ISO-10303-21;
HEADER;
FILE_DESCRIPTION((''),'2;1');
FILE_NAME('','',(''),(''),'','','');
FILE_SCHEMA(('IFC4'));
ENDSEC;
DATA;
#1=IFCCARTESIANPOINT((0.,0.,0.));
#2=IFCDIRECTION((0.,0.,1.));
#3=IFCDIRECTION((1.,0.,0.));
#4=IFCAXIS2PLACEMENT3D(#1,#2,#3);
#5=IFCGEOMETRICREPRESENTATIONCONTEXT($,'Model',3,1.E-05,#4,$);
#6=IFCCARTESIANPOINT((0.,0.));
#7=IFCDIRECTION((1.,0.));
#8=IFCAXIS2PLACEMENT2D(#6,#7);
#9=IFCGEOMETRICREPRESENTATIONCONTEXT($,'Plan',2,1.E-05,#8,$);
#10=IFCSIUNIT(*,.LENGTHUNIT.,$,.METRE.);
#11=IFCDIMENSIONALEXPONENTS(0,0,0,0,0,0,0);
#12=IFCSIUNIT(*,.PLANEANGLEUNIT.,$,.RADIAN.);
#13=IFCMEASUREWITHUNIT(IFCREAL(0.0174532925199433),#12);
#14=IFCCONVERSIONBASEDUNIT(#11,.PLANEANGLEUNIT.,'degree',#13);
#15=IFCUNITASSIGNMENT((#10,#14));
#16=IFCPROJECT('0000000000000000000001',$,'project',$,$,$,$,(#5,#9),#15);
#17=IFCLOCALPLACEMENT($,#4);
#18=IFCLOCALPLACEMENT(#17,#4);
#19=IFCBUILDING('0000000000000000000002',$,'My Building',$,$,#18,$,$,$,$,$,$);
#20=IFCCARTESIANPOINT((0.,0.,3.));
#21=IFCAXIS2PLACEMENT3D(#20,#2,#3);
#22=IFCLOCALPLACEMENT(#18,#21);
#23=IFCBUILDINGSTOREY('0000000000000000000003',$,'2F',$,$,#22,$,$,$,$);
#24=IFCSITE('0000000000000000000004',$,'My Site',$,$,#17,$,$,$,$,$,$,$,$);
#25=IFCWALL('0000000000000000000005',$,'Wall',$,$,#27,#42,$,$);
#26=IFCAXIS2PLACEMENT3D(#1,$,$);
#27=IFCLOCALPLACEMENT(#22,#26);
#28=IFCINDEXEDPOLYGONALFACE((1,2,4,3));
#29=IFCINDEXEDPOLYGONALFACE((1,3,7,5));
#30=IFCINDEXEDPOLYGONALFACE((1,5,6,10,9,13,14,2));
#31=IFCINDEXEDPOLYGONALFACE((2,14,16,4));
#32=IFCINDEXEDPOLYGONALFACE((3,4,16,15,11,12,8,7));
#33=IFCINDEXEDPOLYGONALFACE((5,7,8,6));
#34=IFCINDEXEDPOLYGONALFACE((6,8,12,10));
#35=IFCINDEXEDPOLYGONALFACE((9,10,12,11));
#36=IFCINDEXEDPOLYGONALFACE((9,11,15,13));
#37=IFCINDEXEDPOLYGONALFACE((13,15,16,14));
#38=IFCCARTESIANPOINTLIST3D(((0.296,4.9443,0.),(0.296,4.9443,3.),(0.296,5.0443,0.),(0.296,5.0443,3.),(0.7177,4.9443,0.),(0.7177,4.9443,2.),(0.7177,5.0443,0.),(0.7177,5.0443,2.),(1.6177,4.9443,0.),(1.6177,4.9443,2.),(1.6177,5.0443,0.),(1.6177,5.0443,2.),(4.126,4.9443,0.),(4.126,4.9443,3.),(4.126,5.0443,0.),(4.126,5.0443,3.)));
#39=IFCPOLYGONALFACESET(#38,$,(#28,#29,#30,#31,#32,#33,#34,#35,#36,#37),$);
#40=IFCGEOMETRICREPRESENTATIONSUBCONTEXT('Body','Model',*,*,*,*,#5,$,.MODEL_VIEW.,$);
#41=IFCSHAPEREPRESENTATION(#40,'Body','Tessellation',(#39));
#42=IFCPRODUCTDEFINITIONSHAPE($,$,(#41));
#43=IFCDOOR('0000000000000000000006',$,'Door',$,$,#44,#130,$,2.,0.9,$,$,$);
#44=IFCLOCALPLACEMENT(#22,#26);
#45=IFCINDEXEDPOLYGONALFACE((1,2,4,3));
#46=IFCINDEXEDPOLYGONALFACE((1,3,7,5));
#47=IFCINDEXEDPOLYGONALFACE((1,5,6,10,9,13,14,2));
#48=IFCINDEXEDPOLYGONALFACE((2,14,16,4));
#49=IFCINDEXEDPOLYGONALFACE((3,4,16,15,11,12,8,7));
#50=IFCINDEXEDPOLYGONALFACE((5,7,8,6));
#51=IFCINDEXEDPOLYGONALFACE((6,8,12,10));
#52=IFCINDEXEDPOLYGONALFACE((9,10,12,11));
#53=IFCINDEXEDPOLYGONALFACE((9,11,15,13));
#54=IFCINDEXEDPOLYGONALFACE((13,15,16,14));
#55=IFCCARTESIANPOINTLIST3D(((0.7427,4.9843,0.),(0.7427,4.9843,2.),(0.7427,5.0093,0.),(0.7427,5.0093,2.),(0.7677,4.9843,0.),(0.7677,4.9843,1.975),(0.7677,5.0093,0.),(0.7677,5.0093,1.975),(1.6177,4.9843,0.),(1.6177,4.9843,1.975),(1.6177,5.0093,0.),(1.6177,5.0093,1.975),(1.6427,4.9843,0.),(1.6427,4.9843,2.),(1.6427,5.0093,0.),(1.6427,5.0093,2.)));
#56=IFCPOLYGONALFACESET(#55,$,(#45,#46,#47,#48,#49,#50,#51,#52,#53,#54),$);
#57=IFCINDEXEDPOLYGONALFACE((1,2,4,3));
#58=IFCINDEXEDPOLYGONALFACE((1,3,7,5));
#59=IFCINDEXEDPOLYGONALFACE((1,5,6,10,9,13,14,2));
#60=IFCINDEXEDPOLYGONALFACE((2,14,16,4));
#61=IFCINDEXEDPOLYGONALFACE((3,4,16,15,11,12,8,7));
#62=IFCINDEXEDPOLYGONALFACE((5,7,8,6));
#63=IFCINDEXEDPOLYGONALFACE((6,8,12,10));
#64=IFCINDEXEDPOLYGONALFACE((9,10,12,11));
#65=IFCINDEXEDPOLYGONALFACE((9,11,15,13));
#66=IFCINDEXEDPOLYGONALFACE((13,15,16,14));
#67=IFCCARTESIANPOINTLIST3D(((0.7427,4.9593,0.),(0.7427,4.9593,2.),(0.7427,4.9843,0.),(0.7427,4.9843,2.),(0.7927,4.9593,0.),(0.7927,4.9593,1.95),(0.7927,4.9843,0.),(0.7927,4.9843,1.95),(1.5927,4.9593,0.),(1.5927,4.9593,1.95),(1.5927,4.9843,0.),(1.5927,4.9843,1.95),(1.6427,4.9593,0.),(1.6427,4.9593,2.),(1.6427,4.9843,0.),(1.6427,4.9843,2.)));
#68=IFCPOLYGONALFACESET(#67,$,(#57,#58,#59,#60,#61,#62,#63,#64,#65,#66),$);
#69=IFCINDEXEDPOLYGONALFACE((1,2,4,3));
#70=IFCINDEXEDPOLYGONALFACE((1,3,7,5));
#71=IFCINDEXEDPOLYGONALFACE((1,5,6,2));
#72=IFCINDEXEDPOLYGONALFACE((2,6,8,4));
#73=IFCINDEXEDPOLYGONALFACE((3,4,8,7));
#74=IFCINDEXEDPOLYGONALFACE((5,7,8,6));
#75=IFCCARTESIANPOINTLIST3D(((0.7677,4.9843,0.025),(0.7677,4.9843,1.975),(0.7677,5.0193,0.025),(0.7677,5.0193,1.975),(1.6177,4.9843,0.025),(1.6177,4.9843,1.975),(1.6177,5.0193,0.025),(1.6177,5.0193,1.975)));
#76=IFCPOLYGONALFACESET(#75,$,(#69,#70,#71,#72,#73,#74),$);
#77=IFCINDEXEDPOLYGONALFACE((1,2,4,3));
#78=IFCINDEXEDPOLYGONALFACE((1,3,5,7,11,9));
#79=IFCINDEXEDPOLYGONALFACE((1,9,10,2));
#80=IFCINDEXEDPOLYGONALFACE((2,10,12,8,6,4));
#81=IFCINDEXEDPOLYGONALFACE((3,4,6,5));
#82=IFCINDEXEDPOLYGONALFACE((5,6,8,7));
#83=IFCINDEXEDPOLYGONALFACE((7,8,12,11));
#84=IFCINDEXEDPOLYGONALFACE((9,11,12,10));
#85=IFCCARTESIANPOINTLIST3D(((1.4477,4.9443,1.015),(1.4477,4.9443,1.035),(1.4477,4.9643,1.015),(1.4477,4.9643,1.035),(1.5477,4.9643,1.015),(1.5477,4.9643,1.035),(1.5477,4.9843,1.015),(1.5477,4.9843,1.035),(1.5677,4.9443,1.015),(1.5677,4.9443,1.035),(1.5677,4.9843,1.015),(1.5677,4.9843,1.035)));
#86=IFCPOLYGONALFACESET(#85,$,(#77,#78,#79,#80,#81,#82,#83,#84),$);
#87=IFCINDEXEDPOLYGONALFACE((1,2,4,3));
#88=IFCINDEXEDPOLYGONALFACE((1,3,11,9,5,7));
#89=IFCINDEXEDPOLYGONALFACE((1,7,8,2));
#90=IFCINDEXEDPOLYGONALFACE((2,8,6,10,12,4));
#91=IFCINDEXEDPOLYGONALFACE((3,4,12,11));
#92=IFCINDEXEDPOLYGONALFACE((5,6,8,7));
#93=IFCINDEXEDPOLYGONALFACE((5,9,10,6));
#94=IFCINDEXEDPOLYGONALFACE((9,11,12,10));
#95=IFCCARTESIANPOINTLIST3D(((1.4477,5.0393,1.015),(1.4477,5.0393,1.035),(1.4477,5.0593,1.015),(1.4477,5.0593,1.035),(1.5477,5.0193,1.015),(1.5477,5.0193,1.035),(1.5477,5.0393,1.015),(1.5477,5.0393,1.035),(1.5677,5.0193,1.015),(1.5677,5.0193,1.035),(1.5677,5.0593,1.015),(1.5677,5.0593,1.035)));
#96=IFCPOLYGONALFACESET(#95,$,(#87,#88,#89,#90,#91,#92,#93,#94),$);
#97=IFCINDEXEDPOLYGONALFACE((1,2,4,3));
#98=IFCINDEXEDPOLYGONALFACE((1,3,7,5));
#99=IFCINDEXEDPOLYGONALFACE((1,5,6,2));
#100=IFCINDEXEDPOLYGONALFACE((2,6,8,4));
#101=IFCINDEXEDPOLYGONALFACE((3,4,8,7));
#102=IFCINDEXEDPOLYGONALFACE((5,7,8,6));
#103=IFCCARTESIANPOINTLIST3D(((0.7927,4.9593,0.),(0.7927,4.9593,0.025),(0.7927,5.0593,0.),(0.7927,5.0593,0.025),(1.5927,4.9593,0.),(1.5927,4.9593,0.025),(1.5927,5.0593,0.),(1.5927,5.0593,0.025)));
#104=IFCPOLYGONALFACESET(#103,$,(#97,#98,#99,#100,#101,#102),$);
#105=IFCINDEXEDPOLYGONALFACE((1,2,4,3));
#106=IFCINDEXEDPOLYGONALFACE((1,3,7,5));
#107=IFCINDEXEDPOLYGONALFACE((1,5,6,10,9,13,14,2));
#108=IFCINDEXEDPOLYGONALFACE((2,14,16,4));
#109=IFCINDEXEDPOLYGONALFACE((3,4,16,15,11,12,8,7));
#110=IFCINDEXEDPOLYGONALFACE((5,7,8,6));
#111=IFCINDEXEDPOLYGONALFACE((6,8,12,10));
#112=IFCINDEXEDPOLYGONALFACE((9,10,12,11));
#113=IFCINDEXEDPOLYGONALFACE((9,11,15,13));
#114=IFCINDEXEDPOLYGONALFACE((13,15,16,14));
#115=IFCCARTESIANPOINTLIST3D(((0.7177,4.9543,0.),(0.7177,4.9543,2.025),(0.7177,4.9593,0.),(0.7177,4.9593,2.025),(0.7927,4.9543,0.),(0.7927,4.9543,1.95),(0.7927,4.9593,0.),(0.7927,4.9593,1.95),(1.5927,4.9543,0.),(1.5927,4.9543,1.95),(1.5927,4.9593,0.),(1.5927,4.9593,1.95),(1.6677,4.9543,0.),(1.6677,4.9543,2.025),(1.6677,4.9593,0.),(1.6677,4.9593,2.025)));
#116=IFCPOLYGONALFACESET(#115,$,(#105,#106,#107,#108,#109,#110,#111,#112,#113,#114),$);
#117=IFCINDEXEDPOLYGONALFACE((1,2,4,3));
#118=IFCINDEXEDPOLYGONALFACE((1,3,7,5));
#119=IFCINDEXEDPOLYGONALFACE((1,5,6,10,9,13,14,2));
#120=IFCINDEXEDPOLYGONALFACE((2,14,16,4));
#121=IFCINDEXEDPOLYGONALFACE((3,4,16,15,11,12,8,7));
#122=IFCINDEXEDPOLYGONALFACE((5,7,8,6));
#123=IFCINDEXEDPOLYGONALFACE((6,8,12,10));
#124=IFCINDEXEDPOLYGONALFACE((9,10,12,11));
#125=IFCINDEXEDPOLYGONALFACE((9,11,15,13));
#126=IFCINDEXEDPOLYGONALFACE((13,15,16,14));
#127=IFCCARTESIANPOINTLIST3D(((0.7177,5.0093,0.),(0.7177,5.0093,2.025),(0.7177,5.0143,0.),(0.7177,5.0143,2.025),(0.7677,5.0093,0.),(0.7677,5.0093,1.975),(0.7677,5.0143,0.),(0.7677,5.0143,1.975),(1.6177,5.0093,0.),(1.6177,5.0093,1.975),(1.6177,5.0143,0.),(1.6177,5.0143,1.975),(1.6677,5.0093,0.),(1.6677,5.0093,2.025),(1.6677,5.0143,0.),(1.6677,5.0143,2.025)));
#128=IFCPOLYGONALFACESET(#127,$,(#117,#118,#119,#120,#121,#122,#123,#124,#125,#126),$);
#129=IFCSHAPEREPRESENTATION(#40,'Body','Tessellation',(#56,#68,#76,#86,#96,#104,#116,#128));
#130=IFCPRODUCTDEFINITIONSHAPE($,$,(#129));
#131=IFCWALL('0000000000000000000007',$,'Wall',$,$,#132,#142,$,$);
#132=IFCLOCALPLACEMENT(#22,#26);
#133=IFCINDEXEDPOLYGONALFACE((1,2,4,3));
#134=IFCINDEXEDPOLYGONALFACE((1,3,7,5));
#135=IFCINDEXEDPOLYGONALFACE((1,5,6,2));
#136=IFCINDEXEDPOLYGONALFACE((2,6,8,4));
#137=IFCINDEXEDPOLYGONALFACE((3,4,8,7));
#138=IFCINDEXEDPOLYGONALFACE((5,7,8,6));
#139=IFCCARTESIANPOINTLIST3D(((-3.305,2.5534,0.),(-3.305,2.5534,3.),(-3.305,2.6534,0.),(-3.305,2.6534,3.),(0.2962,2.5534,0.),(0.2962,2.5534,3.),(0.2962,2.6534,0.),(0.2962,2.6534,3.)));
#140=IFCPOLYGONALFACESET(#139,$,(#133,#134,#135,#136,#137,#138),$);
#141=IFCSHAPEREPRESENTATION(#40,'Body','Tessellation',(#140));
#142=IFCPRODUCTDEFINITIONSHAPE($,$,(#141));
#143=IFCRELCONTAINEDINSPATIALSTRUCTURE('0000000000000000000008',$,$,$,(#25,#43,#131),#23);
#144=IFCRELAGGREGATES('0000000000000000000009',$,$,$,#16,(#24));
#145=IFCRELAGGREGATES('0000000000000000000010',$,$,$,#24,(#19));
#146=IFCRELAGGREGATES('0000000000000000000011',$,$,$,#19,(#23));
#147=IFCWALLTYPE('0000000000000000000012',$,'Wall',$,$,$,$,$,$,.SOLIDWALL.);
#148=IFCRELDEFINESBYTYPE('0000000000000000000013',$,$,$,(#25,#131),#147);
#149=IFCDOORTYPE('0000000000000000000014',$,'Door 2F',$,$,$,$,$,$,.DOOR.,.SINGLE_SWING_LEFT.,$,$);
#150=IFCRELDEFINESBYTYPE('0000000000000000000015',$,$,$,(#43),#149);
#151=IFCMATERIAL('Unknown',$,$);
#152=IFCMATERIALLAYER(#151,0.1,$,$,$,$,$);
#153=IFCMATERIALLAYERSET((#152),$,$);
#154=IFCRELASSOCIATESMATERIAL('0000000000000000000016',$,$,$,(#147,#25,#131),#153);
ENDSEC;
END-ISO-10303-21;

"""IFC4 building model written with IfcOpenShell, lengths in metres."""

from ifc_helpers import new_model, entity, si_unit, converted_unit, frame, origin_with_axes, origin_2d_with_axis, place, context, subcontext, project, spatial, line, indexed_curve, outline, extrude, shape, source, transform, mapped, material, layer, layer_set, layer_usage, type_object, type_shapes, element, fill, save


model = new_model("IFC4")

# Units and contexts
model_context = context("Model", 3, precision=1e-05, world=origin_with_axes())
plan_context = context("Plan", 2, precision=1e-05, world=origin_2d_with_axis())
body_context_1 = subcontext(model_context, "Body", "Model", "MODEL_VIEW")
body_context_2 = subcontext(plan_context, "Body", "Plan", "PLAN_VIEW")
ifc_project = project(units=[si_unit("LENGTHUNIT", "METRE"), converted_unit("PLANEANGLEUNIT", "degree", entity("IfcReal", 0.0174532925199433), si_unit("PLANEANGLEUNIT", "RADIAN"), dimensions=[0, 0, 0, 0, 0, 0, 0])], contexts=[model_context, plan_context])

# Site, building, storey
site_placement = place(None, origin_with_axes())
site = spatial("IfcSite", under=ifc_project, at=site_placement, Name="My Site")
building_placement = place(site_placement, origin_with_axes())
building = spatial("IfcBuilding", under=site, at=building_placement, Name="My Building")
storey_placement = place(building_placement, frame((0.0, 0.0, 3.0), z_axis=(0.0, 0.0, 1.0), x_axis=(1.0, 0.0, 0.0)))
storey = spatial("IfcBuildingStorey", under=building, at=storey_placement, Name="2F")

# Shared definitions
ifc_material = material(Name="Unknown")

# Shared definitions
ifc_layer_1 = layer(ifc_material, 0.1)
ifc_layer_set_1 = layer_set([ifc_layer_1])
wall_type = type_object("IfcWallType", Name="Wall", PredefinedType="SOLIDWALL", material=ifc_layer_set_1)

# Wall, opening, door
ifc_layer_usage_1 = layer_usage(ifc_layer_set_1, "AXIS2", "POSITIVE", 0.0)
wall_1_placement = place(storey_placement, frame((4.126, 5.0443, 0.0), z_axis=(0.0, 0.0, 1.0), x_axis=(-1.0, -0.000001, 0.0)))
wall_1 = element("IfcWall", 1, at=wall_1_placement, inside=storey, type_object=wall_type, material=ifc_layer_usage_1, Name="Wall", context=body_context_1, shape_type="SweptSolid", body=[
    extrude(outline(indexed_curve([(0.0, 0.0), (0.0, 0.1), (3.83, 0.1), (3.83, 0.0)], segments=[line(1, 2, 3, 4, 1)])), origin_with_axes(), (0.0, 0.0, 1.0), 3.0),
])
shared_shape_1 = source(origin_with_axes(), body_context_1, "Body", "SweptSolid", [
    extrude(outline(indexed_curve([(0.0, 0.0), (0.9, 0.0), (0.9, 2.0), (0.0, 2.0)], segments=[line(1, 2, 3, 4, 1)])), frame((0.0, -0.6, 0.0), z_axis=(0.0, -1.0, 0.0), x_axis=(1.0, 0.0, 0.0)), (0.0, 0.0, -1.0), 1.2),
])
opening_1_placement = place(wall_1_placement, frame((2.5083, 0.0, 0.0), z_axis=(0.0, 0.0, 1.0), x_axis=(1.0, 0.0, 0.0)))
opening_1 = element("IfcOpeningElement", 2, at=opening_1_placement, cuts=wall_1, PredefinedType="OPENING", context=body_context_1, shape_type="MappedRepresentation", body=[
    mapped(shared_shape_1, transform((0.0, 0.0, 0.0), x_axis=(1.0, 0.0, 0.0), y_axis=(0.0, 1.0, 0.0), z_axis=(0.0, 0.0, 1.0), scale=1.0)),
])
door_type_1 = type_object("IfcDoorType", Name="Door 2F", OperationType="SINGLE_SWING_LEFT", PredefinedType="DOOR")
shared_shape_2 = source(origin_with_axes(), body_context_1, "Body", "SweptSolid", [
    extrude(outline(indexed_curve([(0.0, 0.0), (0.0, 2.0), (0.9, 2.0), (0.9, 0.0), (0.875, 0.0), (0.875, 1.975), (0.025, 1.975), (0.025, 0.0)], segments=[line(1, 2, 3, 4, 5, 6, 7, 8, 1)])), frame((0.0, 0.025, 0.0), z_axis=(0.0, -1.0, 0.0), x_axis=(1.0, 0.0, 0.0)), (0.0, 0.0, -1.0), 0.025),
    extrude(outline(indexed_curve([(0.0, 0.0), (0.0, 2.0), (0.9, 2.0), (0.9, 0.0), (0.85, 0.0), (0.85, 1.95), (0.05, 1.95), (0.05, 0.0)], segments=[line(1, 2, 3, 4, 5, 6, 7, 8, 1)])), frame((0.0, 0.0, 0.0), z_axis=(0.0, -1.0, 0.0), x_axis=(1.0, 0.0, 0.0)), (0.0, 0.0, -1.0), 0.025),
    extrude(outline(indexed_curve([(0.0, 0.0), (0.85, 0.0), (0.85, 0.035), (0.0, 0.035)], segments=[line(1, 2, 3, 4, 1)])), frame((0.025, 0.025, 0.025), z_axis=(0.0, 0.0, 1.0), x_axis=(1.0, 0.0, 0.0)), (0.0, 0.0, 1.0), 1.95),
    extrude(outline(indexed_curve([(0.0, 0.0), (0.0, -0.04), (-0.12, -0.04), (-0.12, -0.02), (-0.02, -0.02), (-0.02, 0.0)], segments=[line(1, 2, 3, 4, 5, 6, 1)])), frame((0.825, 0.025, 1.015), z_axis=(0.0, 0.0, 1.0), x_axis=(1.0, 0.0, 0.0)), (0.0, 0.0, 1.0), 0.02),
    extrude(outline(indexed_curve([(0.0, 0.0), (0.0, 0.04), (-0.12, 0.04), (-0.12, 0.02), (-0.02, 0.02), (-0.02, 0.0)], segments=[line(1, 2, 3, 4, 5, 6, 1)])), frame((0.825, 0.06, 1.015), z_axis=(0.0, 0.0, 1.0), x_axis=(1.0, 0.0, 0.0)), (0.0, 0.0, 1.0), 0.02),
    extrude(outline(indexed_curve([(0.0, 0.0), (0.8, 0.0), (0.8, 0.1), (0.0, 0.1)], segments=[line(1, 2, 3, 4, 1)])), frame((0.05, 0.0, 0.0), z_axis=(0.0, 0.0, 1.0), x_axis=(1.0, 0.0, 0.0)), (0.0, 0.0, 1.0), 0.025),
    extrude(outline(indexed_curve([(0.0, 0.0), (0.0, 2.025), (0.95, 2.025), (0.95, 0.0), (0.875, 0.0), (0.875, 1.95), (0.075, 1.95), (0.075, 0.0)], segments=[line(1, 2, 3, 4, 5, 6, 7, 8, 1)])), frame((-0.025, -0.005, 0.0), z_axis=(0.0, -1.0, 0.0), x_axis=(1.0, 0.0, 0.0)), (0.0, 0.0, -1.0), 0.005),
    extrude(outline(indexed_curve([(0.0, 0.0), (0.0, 2.025), (0.95, 2.025), (0.95, 0.0), (0.9, 0.0), (0.9, 1.975), (0.05, 1.975), (0.05, 0.0)], segments=[line(1, 2, 3, 4, 5, 6, 7, 8, 1)])), frame((-0.025, 0.05, 0.0), z_axis=(0.0, -1.0, 0.0), x_axis=(1.0, 0.0, 0.0)), (0.0, 0.0, -1.0), 0.005),
])
shared_shape_3 = source(origin_with_axes(), body_context_2, "Body", "Curve2D", [
    entity("IfcIndexedPolyCurve", entity("IfcCartesianPointList2D", [[0.0, 0.0], [0.0, 0.05], [0.025, 0.05], [0.025, 0.025], [0.05, 0.025], [0.05, 0.0]]), [entity("IfcLineIndex", [1, 2, 3, 4, 5, 6, 1])]),
    entity("IfcIndexedPolyCurve", entity("IfcCartesianPointList2D", [[0.9, 0.0], [0.9, 0.05], [0.875, 0.05], [0.875, 0.025], [0.85, 0.025], [0.85, 0.0]]), [entity("IfcLineIndex", [1, 2, 3, 4, 5, 6, 1])]),
    entity("IfcTrimmedCurve", entity("IfcEllipse", entity("IfcAxis2Placement2D", entity("IfcCartesianPoint", [0.06, 0.05]), entity("IfcDirection", [1.0, 0.0])), 0.815, 0.85), [entity("IfcCartesianPoint", [0.875, 0.05])], [entity("IfcCartesianPoint", [0.06, 0.9])], True, "CARTESIAN"),
    entity("IfcIndexedPolyCurve", entity("IfcCartesianPointList2D", [[0.025, 0.05], [0.06, 0.05], [0.06, 0.9], [0.025, 0.9]]), [entity("IfcLineIndex", [1, 2, 3, 4, 1])]),
])
type_shapes(door_type_1, [shared_shape_2, shared_shape_3])
door_1_placement = place(opening_1_placement, frame((0.875, 0.085, 0.0), z_axis=(0.0, 0.0, 1.0), x_axis=(-1.0, 0.0, 0.0)))
door_1 = element("IfcDoor", 3, at=door_1_placement, inside=storey, type_object=door_type_1, Name="Door", OverallHeight=2.0, OverallWidth=0.9, shapes=[
    shape(body_context_1, "Body", "MappedRepresentation", [mapped(shared_shape_2, transform((0.0, 0.0, 0.0), x_axis=(1.0, 0.0, 0.0), y_axis=(0.0, 1.0, 0.0), z_axis=(0.0, 0.0, 1.0), scale=1.0))]),
    shape(body_context_2, "Body", "MappedRepresentation", [mapped(shared_shape_3, transform((0.0, 0.0, 0.0), x_axis=(1.0, 0.0, 0.0), y_axis=(0.0, 1.0, 0.0), z_axis=(0.0, 0.0, 1.0), scale=1.0))]),
])
fill(opening_1, door_1)

# Wall
ifc_layer_usage_2 = layer_usage(ifc_layer_set_1, "AXIS2", "POSITIVE", 0.0)
wall_2_placement = place(storey_placement, frame((0.2962, 2.6534, 0.0), z_axis=(0.0, 0.0, 1.0), x_axis=(-1.0, 0.0, 0.0)))
element("IfcWall", 4, at=wall_2_placement, inside=storey, type_object=wall_type, material=ifc_layer_usage_2, Name="Wall", context=body_context_1, shape_type="SweptSolid", body=[
    extrude(outline(indexed_curve([(0.0, 0.0), (0.0, 0.1), (3.6012, 0.1), (3.6012, 0.0)], segments=[line(1, 2, 3, 4, 1)])), origin_with_axes(), (0.0, 0.0, 1.0), 3.0),
])

save(model, "model.ifc")
